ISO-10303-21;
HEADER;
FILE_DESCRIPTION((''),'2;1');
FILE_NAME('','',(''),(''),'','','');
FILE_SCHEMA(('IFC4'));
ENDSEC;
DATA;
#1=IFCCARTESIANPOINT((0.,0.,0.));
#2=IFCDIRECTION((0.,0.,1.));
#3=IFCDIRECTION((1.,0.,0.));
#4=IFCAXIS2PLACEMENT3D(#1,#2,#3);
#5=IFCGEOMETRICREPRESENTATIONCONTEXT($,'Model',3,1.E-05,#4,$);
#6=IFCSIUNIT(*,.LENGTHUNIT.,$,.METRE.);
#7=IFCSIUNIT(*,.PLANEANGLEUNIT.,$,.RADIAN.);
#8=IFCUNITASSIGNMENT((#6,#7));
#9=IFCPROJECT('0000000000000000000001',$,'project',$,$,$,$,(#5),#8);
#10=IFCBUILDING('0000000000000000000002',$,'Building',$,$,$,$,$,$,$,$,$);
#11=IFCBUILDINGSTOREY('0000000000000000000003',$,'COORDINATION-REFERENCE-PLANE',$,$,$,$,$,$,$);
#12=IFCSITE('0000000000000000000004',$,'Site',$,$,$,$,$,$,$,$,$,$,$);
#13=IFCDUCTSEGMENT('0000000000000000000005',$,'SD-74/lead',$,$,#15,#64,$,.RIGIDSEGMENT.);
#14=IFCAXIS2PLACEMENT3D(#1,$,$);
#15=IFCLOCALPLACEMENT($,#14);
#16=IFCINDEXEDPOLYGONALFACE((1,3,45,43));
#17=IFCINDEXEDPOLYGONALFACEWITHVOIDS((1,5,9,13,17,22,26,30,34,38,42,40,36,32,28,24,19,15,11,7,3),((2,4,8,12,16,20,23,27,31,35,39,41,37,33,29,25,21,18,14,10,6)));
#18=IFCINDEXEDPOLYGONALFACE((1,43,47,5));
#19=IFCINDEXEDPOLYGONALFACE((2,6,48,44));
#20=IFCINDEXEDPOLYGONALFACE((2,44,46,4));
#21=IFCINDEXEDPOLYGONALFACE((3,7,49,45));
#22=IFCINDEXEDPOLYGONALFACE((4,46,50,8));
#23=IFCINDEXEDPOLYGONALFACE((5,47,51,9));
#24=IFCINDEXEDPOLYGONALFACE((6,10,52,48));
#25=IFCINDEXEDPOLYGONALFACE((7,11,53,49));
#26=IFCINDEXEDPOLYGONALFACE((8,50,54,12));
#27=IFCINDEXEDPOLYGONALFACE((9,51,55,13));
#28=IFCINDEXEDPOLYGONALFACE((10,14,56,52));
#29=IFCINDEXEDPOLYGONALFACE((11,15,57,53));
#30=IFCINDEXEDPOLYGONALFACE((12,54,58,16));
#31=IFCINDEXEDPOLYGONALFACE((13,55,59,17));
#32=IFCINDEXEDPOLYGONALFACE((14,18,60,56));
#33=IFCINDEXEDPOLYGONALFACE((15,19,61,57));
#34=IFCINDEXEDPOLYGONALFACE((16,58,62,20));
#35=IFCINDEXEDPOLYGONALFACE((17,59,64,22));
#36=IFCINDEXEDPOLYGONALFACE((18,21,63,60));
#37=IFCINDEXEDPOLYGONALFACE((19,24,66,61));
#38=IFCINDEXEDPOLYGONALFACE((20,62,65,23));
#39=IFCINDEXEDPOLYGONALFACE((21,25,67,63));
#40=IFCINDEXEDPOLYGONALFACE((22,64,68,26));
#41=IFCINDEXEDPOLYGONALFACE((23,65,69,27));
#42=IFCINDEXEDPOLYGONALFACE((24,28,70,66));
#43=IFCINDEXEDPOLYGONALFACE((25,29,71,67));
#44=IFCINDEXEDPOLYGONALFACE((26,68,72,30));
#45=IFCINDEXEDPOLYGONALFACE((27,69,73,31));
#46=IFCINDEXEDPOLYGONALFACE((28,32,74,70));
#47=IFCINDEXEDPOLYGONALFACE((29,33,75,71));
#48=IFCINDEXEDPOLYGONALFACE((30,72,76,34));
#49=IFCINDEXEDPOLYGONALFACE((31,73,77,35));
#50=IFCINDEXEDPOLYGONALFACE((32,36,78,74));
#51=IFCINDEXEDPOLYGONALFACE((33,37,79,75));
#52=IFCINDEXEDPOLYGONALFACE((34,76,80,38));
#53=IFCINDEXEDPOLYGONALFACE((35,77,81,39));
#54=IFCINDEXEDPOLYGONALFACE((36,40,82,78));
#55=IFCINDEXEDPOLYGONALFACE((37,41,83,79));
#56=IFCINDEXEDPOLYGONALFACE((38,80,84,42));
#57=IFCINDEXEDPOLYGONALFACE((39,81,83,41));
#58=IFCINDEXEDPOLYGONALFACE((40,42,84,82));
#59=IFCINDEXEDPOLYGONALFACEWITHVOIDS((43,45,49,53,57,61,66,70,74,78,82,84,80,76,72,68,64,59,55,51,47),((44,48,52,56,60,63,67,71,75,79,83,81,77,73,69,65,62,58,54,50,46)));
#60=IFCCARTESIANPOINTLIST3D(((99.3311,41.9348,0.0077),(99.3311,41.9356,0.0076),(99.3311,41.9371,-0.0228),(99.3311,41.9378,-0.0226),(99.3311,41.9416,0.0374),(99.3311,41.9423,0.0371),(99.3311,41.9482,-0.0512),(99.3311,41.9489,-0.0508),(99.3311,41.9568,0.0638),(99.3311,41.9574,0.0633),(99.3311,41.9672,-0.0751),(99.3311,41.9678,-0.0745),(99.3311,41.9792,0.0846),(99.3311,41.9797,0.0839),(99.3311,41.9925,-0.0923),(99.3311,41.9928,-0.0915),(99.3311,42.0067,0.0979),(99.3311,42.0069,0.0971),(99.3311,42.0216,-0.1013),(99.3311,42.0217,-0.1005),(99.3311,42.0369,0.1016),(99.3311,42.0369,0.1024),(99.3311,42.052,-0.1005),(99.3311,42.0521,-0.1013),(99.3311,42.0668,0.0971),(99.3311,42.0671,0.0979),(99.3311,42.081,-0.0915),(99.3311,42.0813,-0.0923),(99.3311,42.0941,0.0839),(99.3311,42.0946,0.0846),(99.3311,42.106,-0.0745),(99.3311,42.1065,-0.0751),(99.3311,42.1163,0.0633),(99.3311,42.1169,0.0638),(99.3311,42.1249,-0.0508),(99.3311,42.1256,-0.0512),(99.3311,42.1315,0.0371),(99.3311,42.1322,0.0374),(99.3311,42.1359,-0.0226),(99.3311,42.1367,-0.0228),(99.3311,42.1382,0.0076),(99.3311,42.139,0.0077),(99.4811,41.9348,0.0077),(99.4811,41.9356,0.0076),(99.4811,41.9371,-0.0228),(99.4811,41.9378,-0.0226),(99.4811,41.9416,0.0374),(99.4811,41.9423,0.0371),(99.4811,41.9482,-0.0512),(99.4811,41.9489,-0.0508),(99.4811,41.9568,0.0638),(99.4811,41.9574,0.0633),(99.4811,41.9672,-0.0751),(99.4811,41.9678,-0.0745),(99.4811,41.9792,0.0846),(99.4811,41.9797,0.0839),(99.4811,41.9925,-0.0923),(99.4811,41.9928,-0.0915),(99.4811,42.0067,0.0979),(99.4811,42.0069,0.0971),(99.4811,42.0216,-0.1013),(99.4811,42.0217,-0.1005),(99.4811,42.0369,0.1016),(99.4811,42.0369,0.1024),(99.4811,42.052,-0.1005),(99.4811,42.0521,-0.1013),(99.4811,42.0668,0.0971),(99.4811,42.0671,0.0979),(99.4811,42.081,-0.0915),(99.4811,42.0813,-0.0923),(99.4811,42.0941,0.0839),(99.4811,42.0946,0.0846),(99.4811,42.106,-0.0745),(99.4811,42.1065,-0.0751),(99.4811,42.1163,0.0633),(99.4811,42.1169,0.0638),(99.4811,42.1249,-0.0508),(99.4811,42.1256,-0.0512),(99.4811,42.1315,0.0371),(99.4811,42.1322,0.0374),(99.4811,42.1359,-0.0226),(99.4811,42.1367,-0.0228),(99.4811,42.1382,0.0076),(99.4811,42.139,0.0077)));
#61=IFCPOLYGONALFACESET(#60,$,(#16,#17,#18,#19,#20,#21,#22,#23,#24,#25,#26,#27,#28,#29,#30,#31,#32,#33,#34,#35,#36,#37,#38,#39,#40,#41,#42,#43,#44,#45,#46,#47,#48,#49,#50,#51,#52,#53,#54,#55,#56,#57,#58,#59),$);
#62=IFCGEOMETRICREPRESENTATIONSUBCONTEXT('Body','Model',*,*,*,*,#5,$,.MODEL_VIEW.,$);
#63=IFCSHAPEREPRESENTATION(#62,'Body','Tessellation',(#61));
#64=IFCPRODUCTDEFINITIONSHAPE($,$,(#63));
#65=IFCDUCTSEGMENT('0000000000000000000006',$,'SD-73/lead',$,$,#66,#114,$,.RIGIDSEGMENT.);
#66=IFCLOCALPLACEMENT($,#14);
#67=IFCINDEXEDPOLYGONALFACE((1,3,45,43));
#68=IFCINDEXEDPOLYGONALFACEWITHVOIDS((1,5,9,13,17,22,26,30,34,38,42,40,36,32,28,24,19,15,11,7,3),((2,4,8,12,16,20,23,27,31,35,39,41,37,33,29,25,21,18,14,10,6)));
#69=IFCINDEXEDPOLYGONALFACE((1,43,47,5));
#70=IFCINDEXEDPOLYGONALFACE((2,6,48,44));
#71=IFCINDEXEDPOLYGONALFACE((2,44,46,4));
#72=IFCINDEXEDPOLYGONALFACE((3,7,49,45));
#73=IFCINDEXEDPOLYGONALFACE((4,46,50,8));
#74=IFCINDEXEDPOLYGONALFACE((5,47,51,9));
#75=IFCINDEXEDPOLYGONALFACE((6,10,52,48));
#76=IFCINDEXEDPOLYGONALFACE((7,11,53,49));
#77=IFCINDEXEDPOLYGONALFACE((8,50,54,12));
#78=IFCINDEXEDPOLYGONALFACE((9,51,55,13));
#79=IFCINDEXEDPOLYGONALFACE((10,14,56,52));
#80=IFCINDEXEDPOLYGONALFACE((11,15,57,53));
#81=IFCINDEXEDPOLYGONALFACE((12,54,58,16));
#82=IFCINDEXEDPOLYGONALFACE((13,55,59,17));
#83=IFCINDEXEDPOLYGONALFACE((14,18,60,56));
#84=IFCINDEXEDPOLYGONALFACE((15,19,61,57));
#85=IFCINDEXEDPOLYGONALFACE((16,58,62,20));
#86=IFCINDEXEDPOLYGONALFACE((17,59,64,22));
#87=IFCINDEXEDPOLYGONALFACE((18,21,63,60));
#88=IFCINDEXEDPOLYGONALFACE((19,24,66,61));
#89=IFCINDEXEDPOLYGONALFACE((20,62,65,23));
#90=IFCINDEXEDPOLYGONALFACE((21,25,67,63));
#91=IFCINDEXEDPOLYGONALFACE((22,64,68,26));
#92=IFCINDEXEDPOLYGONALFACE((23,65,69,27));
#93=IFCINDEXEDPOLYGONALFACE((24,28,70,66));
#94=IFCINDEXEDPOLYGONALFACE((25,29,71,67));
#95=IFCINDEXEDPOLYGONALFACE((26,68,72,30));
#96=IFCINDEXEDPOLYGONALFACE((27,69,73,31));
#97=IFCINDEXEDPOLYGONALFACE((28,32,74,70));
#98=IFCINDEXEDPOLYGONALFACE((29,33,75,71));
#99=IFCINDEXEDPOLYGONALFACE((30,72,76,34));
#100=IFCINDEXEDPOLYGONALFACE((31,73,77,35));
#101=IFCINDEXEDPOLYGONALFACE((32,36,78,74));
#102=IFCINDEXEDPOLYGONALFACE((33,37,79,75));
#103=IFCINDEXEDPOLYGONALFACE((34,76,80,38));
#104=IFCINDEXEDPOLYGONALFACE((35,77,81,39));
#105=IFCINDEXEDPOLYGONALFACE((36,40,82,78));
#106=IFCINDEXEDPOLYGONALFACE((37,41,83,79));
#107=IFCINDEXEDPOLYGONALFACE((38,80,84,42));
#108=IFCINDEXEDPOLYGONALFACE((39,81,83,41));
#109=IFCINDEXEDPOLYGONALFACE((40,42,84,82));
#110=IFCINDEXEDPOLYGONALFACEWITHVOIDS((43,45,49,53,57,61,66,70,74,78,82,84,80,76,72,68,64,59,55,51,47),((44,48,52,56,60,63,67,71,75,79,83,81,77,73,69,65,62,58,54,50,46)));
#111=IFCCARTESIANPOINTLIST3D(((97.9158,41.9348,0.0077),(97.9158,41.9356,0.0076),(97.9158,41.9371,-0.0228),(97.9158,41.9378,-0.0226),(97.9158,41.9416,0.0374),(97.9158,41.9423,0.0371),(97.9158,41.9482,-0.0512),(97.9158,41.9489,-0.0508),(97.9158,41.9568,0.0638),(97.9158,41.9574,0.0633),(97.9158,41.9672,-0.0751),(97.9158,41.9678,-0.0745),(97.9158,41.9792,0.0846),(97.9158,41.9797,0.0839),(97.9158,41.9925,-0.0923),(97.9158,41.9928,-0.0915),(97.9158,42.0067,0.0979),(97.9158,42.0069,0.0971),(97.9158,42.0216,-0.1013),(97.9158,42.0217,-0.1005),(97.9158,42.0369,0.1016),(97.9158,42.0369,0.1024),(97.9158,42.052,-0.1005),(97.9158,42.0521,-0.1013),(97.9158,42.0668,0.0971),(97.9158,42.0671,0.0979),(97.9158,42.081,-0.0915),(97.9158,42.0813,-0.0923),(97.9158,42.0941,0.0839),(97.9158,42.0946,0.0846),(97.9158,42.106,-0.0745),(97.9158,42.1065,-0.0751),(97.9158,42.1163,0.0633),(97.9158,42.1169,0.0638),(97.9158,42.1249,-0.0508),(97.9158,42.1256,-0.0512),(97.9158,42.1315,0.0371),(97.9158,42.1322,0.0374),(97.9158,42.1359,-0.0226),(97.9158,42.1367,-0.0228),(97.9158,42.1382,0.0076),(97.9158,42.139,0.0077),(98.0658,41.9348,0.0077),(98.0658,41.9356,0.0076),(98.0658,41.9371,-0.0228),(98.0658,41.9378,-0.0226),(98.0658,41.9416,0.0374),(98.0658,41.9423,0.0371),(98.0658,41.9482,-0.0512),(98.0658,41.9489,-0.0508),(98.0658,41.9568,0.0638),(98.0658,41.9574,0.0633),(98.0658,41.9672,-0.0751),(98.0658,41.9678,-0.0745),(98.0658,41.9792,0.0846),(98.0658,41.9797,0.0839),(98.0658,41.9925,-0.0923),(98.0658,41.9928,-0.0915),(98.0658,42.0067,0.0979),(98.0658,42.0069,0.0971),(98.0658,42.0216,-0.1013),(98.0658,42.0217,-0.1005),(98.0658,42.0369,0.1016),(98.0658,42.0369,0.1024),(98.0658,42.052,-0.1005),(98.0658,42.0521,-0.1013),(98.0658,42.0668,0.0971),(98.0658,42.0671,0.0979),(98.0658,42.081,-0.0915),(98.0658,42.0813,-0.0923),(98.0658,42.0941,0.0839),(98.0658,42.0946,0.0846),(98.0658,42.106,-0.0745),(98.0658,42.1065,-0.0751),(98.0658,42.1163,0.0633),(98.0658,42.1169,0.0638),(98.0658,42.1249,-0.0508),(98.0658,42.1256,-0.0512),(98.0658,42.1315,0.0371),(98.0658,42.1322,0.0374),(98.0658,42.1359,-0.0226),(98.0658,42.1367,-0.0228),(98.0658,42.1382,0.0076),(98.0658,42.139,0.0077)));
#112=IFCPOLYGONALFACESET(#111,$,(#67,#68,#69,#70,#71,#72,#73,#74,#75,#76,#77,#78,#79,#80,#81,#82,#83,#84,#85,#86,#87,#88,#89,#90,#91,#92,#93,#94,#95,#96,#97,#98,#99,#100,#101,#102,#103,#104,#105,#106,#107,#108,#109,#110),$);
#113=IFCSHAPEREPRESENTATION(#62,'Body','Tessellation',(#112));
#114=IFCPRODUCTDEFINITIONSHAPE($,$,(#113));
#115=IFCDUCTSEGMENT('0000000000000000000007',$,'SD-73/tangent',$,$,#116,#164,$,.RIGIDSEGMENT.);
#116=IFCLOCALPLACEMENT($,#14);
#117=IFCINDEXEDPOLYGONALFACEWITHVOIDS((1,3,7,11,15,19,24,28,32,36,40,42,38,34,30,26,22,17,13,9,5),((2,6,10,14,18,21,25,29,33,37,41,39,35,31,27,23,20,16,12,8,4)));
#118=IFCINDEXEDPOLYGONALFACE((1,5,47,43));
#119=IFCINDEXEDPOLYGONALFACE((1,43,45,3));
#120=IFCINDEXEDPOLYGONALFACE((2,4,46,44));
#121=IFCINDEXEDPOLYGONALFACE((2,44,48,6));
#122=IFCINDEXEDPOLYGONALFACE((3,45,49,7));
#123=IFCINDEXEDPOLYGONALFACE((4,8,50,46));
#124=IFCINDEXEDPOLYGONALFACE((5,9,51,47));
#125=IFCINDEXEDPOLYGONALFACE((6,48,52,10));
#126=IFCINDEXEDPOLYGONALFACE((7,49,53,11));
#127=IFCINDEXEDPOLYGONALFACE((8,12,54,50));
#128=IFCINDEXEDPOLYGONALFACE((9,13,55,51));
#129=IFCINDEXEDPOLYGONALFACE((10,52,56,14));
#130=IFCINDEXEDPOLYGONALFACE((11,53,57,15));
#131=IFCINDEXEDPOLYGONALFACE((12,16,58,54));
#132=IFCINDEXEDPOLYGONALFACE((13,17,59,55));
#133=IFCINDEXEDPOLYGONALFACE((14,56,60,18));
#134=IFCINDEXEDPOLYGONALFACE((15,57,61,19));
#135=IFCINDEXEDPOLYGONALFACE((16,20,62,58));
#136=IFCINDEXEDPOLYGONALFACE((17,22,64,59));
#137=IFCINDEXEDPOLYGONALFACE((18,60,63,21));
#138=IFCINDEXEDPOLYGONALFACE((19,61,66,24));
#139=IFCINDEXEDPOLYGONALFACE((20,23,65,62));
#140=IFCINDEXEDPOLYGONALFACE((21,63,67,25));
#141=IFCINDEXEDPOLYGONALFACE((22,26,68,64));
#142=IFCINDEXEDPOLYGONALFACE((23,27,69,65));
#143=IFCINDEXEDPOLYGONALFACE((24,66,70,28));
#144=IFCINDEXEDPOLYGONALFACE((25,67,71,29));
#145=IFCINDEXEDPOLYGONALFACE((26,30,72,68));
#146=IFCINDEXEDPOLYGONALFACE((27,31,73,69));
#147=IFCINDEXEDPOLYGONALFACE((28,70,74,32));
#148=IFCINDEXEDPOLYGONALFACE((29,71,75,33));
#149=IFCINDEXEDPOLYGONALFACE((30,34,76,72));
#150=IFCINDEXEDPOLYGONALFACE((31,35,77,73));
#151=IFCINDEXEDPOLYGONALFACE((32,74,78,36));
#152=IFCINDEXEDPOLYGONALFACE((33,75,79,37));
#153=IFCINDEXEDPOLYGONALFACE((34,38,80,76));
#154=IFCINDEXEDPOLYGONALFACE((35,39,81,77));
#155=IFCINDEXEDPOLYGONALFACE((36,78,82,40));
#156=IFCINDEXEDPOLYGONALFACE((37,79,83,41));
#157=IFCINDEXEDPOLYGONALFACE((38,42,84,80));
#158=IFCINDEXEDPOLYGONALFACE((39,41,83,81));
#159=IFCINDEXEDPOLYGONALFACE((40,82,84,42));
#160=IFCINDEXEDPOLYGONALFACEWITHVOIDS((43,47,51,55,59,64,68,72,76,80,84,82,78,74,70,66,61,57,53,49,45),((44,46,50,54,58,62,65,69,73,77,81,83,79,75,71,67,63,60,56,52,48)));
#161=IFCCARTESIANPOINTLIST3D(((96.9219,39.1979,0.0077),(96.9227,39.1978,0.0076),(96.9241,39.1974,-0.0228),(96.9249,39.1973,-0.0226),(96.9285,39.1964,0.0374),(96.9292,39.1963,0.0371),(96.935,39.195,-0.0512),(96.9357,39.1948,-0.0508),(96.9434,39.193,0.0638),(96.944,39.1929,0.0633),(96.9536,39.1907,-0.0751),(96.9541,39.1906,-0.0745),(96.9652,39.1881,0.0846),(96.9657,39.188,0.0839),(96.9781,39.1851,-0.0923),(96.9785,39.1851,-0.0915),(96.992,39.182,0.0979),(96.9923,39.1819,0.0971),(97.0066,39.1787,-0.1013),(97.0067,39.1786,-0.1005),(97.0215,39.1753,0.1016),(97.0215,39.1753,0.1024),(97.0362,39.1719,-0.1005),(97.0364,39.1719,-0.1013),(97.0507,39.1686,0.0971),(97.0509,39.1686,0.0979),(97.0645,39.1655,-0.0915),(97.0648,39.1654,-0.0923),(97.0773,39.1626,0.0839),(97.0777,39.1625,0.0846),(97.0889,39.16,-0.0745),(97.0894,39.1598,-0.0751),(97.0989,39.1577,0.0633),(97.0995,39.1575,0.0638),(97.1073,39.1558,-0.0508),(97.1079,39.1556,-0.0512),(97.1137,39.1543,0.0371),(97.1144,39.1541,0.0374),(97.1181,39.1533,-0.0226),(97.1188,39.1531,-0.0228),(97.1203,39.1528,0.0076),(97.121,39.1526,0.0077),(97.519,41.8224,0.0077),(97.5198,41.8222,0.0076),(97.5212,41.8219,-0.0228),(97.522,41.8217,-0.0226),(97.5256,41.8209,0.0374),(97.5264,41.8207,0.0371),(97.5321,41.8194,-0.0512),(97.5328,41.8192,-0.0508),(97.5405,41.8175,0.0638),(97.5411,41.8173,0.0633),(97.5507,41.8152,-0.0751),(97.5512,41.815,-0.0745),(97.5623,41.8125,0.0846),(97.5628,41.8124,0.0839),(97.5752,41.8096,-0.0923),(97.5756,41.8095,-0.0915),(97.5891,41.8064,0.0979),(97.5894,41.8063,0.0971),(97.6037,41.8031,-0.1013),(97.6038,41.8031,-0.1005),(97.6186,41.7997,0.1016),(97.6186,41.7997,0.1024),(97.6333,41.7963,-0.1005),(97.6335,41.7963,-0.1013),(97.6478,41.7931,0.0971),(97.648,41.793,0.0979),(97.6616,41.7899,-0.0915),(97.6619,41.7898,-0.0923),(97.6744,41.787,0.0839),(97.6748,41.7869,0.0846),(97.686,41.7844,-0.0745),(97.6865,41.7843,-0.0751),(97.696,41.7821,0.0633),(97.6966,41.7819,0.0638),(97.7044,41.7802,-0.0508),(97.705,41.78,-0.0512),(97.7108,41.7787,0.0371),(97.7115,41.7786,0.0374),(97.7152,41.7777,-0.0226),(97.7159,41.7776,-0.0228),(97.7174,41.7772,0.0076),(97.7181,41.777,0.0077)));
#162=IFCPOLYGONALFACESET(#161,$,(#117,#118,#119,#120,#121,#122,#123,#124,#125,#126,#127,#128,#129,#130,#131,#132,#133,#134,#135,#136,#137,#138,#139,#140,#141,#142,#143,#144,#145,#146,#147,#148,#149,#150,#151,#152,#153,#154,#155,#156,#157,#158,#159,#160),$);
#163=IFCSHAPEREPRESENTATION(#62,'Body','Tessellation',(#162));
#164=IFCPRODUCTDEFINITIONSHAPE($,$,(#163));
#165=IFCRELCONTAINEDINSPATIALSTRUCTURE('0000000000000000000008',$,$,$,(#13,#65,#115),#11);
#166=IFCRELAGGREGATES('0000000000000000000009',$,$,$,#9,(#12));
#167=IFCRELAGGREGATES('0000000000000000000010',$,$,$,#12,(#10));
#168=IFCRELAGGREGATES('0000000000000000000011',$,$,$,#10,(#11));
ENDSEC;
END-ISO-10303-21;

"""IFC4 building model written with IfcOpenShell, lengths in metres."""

from ifc_helpers import new_model, si_unit, frame, origin_with_axes, place, context, subcontext, project, spatial, hollow_circle, extrude, element, save


model = new_model("IFC4")

# Units and contexts
model_context = context("Model", 3, precision=1e-05, world=origin_with_axes())
body_context_1 = subcontext(model_context, "Body", "Model", "MODEL_VIEW")
ifc_project = project(units=[si_unit("LENGTHUNIT", "METRE"), si_unit("PLANEANGLEUNIT", "RADIAN")], contexts=[model_context])

# Site, building, storey
site = spatial("IfcSite", under=ifc_project, Name="Site")
building = spatial("IfcBuilding", under=site, Name="Building")
storey = spatial("IfcBuildingStorey", under=building, Name="COORDINATION-REFERENCE-PLANE")

# Duct segments
for number, where, z_axis, x_axis, name in (
    (1, (99.3311, 42.0369, 0.0), (1.0, 0.0, 0.0), (0.0, 0.0, 1.0), "SD-74/lead"),
    (2, (98.0658, 42.0369, 0.0), (-1.0, 0.0, 0.0), (0.0, 0.0, 1.0), "SD-73/lead"),
):
    element("IfcDuctSegment", number, at=place(None, frame(where, z_axis=z_axis, x_axis=x_axis)), inside=storey, Name=name, PredefinedType="RIGIDSEGMENT", context=body_context_1, shape_type="SweptSolid", body=[
        extrude(hollow_circle(Radius=0.1024, WallThickness=0.0008), origin_with_axes(), (0.0, 0.0, 1.0), 0.15),
    ])

# Duct segment
duct_segment_1_placement = place(None, frame((97.6186, 41.7997, 0.0), z_axis=(-0.221849, -0.975081, 0.0), x_axis=(0.0, 0.0, 1.0)))
element("IfcDuctSegment", 3, at=duct_segment_1_placement, inside=storey, Name="SD-73/tangent", PredefinedType="RIGIDSEGMENT", context=body_context_1, shape_type="SweptSolid", body=[
    extrude(hollow_circle(Radius=0.1024, WallThickness=0.0008), origin_with_axes(), (0.0, 0.0, 1.0), 2.6915),
])

save(model, "model.ifc")
